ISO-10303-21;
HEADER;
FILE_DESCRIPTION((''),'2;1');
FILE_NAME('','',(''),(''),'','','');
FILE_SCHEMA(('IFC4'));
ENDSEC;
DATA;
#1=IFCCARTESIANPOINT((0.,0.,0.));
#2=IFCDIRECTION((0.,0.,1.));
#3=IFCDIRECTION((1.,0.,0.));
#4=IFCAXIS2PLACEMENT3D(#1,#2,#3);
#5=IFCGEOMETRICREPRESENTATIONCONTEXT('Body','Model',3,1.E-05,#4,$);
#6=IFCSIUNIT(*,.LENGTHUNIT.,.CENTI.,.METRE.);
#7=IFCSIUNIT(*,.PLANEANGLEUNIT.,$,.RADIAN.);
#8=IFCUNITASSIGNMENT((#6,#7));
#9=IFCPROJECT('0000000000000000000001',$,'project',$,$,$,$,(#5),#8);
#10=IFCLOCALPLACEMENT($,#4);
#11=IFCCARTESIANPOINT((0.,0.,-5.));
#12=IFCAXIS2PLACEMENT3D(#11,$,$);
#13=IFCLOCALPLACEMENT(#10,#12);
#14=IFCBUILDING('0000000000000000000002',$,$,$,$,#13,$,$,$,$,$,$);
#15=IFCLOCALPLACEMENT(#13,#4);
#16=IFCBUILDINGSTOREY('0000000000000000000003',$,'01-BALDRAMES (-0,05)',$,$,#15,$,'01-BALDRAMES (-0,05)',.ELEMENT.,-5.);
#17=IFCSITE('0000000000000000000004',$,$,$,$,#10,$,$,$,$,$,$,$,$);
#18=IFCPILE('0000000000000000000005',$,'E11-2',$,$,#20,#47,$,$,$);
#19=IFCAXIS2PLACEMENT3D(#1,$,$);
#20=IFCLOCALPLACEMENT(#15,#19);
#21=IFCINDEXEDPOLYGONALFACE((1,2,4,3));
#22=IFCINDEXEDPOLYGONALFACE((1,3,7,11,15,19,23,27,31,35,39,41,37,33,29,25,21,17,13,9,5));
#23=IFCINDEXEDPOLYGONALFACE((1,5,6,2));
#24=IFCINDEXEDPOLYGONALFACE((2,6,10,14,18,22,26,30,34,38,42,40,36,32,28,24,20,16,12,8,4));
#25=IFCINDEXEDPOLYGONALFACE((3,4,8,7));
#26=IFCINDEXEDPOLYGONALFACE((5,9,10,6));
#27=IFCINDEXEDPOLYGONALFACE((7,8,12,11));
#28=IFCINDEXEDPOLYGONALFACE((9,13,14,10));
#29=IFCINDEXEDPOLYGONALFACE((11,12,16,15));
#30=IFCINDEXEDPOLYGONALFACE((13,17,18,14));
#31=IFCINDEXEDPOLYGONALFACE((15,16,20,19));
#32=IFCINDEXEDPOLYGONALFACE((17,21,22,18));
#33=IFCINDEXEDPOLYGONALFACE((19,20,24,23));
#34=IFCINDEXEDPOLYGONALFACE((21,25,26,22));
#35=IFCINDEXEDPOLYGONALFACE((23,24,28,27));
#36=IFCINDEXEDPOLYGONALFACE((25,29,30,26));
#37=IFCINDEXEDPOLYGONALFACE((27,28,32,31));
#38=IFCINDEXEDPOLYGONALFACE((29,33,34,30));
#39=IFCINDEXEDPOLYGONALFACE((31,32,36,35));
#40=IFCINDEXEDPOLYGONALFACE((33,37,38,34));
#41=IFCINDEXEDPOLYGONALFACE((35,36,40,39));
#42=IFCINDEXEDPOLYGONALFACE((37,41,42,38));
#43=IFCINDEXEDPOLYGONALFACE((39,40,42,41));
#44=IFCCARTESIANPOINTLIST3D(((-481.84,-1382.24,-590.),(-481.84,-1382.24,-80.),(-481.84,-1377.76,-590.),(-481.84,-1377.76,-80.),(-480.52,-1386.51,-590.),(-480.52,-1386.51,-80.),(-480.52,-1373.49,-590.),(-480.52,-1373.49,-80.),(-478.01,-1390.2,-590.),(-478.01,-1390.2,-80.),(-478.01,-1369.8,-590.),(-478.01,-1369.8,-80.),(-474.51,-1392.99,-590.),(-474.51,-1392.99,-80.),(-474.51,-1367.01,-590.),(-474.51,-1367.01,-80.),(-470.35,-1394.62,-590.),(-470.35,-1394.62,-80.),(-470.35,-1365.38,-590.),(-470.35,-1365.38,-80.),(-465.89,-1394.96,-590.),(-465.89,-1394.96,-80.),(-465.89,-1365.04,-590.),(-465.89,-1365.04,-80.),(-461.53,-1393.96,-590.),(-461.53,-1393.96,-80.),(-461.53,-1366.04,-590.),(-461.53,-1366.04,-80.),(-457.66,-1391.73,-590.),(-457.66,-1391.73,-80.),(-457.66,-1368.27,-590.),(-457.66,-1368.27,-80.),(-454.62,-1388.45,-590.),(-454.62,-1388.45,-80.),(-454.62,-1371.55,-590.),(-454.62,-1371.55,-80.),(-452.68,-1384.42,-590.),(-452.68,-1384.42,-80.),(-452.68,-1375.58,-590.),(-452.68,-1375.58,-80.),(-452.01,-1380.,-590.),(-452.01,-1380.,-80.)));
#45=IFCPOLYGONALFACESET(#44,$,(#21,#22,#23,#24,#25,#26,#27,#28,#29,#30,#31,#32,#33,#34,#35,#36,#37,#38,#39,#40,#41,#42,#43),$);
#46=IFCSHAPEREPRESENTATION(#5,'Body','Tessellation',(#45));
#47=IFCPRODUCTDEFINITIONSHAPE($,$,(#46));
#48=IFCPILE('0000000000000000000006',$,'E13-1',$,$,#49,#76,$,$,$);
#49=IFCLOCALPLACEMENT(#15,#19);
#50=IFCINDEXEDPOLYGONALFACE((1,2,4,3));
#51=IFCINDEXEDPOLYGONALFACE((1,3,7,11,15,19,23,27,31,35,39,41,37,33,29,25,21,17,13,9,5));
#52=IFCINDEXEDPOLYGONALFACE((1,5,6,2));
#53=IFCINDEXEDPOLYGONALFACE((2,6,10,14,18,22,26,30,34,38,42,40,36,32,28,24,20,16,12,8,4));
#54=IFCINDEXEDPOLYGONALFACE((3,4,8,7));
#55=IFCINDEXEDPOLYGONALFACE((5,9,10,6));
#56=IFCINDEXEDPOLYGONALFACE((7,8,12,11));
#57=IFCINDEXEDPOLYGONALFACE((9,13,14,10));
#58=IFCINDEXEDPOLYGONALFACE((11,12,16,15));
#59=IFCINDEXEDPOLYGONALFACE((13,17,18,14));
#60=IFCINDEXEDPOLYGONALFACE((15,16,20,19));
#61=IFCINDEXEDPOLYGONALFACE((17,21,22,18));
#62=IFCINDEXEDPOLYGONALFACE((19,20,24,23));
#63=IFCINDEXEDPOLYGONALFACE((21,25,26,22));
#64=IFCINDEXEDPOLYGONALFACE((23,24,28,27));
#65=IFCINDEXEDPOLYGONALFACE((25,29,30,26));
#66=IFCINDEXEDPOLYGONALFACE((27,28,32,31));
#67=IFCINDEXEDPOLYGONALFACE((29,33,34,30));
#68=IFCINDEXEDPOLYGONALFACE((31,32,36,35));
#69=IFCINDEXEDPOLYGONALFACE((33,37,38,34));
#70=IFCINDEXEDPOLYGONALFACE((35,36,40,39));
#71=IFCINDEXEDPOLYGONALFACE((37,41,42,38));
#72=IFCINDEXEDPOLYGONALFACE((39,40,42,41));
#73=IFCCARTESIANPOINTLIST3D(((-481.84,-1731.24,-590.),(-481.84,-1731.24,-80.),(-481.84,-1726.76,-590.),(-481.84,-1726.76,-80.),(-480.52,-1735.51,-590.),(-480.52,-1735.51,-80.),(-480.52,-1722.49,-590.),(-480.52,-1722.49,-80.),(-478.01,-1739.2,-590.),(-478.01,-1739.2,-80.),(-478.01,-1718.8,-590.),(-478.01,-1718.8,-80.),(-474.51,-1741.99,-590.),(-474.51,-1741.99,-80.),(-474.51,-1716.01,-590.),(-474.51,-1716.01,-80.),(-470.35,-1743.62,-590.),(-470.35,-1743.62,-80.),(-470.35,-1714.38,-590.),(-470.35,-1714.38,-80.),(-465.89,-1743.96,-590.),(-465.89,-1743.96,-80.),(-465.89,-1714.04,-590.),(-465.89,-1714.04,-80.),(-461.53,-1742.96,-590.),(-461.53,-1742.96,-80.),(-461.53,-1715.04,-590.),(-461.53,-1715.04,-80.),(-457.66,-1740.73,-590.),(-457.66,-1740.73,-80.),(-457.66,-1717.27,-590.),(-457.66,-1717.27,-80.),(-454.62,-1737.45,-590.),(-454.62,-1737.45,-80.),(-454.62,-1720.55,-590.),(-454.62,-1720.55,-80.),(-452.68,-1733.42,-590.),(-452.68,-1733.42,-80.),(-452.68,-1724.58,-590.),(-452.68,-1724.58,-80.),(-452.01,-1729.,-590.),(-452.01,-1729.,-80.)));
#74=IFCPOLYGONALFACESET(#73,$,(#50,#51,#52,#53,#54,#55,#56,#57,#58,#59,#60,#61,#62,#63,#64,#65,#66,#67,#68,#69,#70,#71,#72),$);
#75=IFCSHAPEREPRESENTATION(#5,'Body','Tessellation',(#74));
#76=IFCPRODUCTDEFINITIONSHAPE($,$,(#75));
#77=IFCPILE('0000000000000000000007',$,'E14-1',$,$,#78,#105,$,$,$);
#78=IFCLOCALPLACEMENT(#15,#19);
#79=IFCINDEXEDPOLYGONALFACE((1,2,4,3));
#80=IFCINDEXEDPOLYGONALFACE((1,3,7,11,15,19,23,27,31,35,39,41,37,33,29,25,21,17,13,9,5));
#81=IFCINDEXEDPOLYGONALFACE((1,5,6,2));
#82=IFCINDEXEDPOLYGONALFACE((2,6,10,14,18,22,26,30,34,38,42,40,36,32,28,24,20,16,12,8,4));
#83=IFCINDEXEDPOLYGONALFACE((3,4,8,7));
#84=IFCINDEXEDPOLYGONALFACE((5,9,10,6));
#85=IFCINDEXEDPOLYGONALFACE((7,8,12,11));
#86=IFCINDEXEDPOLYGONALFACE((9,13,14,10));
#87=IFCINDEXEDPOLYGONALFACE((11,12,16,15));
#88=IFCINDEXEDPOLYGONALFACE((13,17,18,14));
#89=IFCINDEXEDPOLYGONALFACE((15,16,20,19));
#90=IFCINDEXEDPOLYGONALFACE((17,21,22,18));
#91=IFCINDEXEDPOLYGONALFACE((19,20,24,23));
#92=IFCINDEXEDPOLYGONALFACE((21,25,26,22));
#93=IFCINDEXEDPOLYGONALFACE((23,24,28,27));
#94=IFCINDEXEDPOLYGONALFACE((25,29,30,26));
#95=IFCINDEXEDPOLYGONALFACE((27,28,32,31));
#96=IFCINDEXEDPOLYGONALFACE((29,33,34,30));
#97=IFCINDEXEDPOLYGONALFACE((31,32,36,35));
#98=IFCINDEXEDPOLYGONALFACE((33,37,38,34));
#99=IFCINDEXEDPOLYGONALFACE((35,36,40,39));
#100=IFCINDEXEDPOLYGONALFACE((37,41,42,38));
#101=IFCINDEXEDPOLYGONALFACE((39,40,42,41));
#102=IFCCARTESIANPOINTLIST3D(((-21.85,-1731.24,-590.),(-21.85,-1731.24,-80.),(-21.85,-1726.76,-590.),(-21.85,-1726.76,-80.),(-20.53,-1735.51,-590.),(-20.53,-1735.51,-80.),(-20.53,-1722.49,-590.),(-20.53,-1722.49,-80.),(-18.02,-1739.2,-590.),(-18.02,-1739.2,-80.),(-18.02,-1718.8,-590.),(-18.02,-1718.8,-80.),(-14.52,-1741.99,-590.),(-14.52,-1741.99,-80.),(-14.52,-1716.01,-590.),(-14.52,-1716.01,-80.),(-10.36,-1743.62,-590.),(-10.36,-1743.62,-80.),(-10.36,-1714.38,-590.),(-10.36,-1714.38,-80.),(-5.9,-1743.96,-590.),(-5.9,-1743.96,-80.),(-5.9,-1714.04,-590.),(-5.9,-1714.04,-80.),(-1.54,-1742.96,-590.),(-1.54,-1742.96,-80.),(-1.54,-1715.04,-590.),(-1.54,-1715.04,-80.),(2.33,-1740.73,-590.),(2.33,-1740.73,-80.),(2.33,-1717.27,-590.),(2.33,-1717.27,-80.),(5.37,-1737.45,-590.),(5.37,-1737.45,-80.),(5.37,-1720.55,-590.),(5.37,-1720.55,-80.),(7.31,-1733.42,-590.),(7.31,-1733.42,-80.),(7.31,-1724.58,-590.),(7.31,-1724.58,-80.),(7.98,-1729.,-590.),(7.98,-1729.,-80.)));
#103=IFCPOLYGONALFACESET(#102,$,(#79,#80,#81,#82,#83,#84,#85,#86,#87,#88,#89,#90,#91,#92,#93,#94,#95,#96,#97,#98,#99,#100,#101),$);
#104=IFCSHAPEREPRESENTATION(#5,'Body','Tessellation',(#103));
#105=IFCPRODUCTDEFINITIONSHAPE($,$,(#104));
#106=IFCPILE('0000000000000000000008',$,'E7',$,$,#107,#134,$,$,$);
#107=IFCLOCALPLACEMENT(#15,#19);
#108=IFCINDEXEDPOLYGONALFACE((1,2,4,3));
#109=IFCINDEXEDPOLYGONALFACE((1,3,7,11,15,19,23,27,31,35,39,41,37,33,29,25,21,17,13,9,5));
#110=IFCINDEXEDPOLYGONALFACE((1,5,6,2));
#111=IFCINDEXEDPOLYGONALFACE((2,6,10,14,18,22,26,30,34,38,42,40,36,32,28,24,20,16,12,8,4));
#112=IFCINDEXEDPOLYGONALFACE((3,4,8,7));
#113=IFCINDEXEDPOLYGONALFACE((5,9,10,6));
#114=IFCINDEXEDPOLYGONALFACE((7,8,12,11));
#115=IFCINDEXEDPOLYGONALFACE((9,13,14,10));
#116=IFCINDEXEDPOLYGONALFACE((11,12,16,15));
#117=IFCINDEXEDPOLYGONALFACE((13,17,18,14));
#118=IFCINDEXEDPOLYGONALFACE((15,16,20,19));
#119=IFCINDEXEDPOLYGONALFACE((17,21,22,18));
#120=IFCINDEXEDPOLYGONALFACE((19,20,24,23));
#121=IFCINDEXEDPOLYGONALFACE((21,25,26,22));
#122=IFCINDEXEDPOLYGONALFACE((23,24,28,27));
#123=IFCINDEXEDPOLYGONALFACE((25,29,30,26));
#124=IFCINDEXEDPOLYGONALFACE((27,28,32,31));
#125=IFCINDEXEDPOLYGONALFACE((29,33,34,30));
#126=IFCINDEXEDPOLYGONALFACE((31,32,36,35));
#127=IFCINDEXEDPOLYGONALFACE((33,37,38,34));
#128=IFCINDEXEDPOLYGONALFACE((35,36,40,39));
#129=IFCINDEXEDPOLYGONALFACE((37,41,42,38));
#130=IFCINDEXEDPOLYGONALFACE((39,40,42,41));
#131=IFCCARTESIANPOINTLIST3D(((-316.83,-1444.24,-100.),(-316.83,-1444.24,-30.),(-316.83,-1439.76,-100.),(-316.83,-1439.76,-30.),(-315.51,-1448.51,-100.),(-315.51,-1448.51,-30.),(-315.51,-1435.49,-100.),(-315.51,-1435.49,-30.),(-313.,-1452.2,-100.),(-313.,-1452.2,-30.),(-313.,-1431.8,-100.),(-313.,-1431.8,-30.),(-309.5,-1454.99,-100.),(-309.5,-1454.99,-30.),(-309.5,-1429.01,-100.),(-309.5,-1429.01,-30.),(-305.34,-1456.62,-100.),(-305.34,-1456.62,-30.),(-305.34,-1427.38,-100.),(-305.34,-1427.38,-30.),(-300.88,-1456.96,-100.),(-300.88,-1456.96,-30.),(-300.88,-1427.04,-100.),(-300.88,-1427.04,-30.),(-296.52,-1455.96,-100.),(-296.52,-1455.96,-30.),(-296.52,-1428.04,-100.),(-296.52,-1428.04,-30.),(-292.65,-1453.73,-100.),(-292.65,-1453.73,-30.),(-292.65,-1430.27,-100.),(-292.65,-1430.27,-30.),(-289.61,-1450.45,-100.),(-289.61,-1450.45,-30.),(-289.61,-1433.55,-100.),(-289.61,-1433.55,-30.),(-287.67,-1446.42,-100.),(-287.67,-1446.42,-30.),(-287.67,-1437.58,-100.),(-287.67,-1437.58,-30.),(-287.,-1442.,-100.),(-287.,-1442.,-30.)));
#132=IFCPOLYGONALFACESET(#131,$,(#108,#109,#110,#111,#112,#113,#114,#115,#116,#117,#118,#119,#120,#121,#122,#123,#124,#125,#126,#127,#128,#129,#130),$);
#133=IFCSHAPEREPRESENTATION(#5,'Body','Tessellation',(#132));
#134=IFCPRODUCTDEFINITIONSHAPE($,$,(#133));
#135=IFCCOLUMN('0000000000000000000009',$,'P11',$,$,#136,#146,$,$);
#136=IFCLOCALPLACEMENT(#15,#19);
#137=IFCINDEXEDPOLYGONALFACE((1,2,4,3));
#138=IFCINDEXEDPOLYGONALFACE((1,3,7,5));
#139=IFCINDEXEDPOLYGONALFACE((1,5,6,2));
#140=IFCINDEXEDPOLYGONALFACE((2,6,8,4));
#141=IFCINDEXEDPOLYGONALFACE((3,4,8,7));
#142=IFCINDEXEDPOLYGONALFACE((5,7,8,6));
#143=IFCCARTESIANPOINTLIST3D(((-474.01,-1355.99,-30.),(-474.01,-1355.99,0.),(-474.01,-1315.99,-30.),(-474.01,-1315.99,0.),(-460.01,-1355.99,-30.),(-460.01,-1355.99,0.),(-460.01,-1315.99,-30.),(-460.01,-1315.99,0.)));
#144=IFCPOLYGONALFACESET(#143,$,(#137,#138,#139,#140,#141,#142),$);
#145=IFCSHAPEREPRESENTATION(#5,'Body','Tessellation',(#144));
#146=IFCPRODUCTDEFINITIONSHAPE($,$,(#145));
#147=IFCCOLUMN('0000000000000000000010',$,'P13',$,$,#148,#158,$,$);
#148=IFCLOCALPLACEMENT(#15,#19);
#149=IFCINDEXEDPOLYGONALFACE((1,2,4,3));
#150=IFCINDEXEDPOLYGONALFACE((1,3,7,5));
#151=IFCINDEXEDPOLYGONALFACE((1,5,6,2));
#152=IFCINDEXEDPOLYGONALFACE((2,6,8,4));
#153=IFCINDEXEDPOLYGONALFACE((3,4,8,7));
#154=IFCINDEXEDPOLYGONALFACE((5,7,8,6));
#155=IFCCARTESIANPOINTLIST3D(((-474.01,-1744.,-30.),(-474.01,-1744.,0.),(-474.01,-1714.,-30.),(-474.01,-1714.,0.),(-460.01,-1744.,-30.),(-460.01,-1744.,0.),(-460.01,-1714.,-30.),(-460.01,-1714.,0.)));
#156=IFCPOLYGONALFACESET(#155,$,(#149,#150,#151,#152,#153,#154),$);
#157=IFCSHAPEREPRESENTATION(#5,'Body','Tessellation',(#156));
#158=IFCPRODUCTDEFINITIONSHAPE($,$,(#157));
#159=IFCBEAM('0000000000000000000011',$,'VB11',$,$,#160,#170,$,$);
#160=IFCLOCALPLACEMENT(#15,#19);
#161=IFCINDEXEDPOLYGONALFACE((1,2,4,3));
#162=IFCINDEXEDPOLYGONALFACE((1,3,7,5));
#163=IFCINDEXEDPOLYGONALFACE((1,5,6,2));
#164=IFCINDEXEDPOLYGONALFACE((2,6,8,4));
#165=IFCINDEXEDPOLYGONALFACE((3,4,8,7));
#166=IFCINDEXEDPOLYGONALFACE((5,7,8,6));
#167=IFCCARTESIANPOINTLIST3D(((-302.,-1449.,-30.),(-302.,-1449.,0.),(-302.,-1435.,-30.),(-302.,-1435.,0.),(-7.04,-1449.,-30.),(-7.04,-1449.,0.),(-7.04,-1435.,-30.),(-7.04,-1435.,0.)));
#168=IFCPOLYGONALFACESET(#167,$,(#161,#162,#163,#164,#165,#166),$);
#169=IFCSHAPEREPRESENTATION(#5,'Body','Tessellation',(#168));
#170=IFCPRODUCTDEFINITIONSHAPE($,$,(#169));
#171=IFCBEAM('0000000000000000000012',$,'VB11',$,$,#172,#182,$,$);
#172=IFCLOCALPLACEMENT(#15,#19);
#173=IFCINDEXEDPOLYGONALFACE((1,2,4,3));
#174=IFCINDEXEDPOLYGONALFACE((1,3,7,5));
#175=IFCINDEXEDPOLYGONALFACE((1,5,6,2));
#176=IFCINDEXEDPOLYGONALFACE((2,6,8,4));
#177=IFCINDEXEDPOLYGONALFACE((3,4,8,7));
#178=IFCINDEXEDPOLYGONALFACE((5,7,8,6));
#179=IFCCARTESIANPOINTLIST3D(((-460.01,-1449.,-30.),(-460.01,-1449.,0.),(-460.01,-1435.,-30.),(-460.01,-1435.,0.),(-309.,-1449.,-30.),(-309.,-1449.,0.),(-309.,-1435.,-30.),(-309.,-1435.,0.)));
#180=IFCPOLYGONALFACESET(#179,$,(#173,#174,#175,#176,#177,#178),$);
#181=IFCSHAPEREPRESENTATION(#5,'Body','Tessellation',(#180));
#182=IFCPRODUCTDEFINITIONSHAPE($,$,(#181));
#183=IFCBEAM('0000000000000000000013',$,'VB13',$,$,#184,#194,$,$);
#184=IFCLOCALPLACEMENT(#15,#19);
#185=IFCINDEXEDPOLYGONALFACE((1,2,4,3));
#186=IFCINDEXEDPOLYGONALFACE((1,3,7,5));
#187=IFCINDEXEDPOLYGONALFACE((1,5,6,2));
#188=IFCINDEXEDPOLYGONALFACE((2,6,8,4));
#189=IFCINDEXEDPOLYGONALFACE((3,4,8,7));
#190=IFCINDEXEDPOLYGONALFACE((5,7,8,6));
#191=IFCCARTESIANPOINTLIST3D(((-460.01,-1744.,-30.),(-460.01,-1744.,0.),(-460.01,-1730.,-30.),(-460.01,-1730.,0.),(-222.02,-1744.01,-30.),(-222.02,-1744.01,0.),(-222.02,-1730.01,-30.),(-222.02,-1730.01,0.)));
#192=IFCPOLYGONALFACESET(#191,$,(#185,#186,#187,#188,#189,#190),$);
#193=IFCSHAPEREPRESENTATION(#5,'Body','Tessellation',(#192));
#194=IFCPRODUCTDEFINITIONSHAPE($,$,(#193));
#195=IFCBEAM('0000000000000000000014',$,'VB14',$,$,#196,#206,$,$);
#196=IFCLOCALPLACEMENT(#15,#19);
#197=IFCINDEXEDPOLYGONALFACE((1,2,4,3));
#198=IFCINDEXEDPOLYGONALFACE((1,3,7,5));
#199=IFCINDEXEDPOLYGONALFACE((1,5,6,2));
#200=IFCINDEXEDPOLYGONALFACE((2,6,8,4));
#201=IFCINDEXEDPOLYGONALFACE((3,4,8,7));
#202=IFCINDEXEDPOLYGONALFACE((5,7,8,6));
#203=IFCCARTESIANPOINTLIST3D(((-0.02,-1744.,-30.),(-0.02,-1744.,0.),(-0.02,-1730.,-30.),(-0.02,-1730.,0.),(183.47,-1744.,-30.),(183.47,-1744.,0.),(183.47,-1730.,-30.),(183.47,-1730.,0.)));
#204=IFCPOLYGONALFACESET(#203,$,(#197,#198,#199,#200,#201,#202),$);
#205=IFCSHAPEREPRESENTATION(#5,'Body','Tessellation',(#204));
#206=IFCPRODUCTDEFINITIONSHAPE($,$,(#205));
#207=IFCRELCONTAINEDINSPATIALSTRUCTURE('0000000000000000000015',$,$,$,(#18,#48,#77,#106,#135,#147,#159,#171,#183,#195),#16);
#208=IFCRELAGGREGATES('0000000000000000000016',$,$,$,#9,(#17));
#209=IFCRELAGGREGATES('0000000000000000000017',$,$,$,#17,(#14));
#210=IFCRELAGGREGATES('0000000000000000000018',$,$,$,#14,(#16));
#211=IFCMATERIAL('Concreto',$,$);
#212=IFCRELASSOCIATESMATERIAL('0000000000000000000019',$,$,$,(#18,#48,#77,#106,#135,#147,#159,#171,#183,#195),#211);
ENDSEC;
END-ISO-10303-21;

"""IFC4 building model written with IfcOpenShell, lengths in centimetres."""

from ifc_helpers import new_model, si_unit, frame, origin_with_axes, origin_2d_with_axis, place, context, project, spatial, rectangle, circle, extrude, material, element, save


model = new_model("IFC4")

# Units and contexts
model_context = context("Model", 3, precision=1e-05, world=origin_with_axes(), identifier="Body")
ifc_project = project(units=[si_unit("LENGTHUNIT", "METRE", prefix="CENTI"), si_unit("PLANEANGLEUNIT", "RADIAN")], contexts=[model_context])

# Site, building, storey
site_placement = place(None, origin_with_axes())
site = spatial("IfcSite", under=ifc_project, at=site_placement)
building_placement = place(site_placement, frame((0.0, 0.0, -5.0)))
building = spatial("IfcBuilding", under=site, at=building_placement)
storey_placement = place(building_placement, origin_with_axes())
storey = spatial("IfcBuildingStorey", under=building, at=storey_placement, Name="01-BALDRAMES (-0,05)", LongName="01-BALDRAMES (-0,05)", CompositionType="ELEMENT", Elevation=-5.0)

# Piles
ifc_material = material(Name="Concreto")
for number, where, z_axis, x_axis, name in (
    (1, (-467.01, -1380.0, -80.0), (0.0, 0.0, 1.0), (1.0, 0.0, 0.0), "E11-2"),
    (2, (-467.01, -1729.0, -80.0), (0.0, 0.0, 1.0), (1.0, 0.0, 0.0), "E13-1"),
    (3, (-7.02, -1729.0, -80.0), (0.0, 0.0, 1.0), (1.0, 0.0, 0.0), "E14-1"),
):
    element("IfcPile", number, at=place(storey_placement, frame(where, z_axis=z_axis, x_axis=x_axis)), inside=storey, material=ifc_material, Name=name, context=model_context, shape_type="SweptSolid", body=[
        extrude(circle(Radius=15.0, at=origin_2d_with_axis()), frame((0.0, 0.0, -510.0), z_axis=(0.0, 0.0, 1.0), x_axis=(1.0, 0.0, 0.0)), (0.0, 0.0, 1.0), 510.0),
    ])
pile_placement = place(storey_placement, frame((-302.0, -1442.0, -30.0), z_axis=(0.0, 0.0, 1.0), x_axis=(1.0, 0.0, 0.0)))
element("IfcPile", 4, at=pile_placement, inside=storey, material=ifc_material, Name="E7", context=model_context, shape_type="SolidModel", body=[
    extrude(circle(Radius=15.0, at=origin_2d_with_axis()), frame((0.0, 0.0, -70.0), z_axis=(0.0, 0.0, 1.0), x_axis=(1.0, 0.0, 0.0)), (0.0, 0.0, 1.0), 70.0),
])

# Columns
column_1_placement = place(storey_placement, frame((-467.01, -1335.99, 0.0), z_axis=(0.0, 0.0, 1.0), x_axis=(1.0, 0.0, 0.0)))
element("IfcColumn", 5, at=column_1_placement, inside=storey, material=ifc_material, Name="P11", context=model_context, shape_type="SolidModel", body=[
    extrude(rectangle(XDim=14.0, YDim=40.0, at=origin_2d_with_axis()), origin_with_axes(), (0.0, 0.0, -1.0), 30.0),
])
column_2_placement = place(storey_placement, frame((-467.01, -1729.0, 0.0), z_axis=(0.0, 0.0, 1.0), x_axis=(1.0, 0.0, 0.0)))
element("IfcColumn", 6, at=column_2_placement, inside=storey, material=ifc_material, Name="P13", context=model_context, shape_type="SolidModel", body=[
    extrude(rectangle(XDim=14.0, YDim=30.0, at=origin_2d_with_axis()), origin_with_axes(), (0.0, 0.0, -1.0), 30.0),
])

# Beams
beam_1_placement = place(storey_placement, frame((-154.52, -1442.0, 0.0), z_axis=(0.0, 0.0, 1.0), x_axis=(1.0, 0.0, 0.0)))
element("IfcBeam", 7, at=beam_1_placement, inside=storey, material=ifc_material, Name="VB11", context=model_context, shape_type="SolidModel", body=[
    extrude(rectangle(XDim=14.0, YDim=30.0, at=origin_2d_with_axis()), frame((-147.48, 0.0, -15.0), z_axis=(1.0, 0.0, 0.0), x_axis=(0.0, -1.0, 0.0)), (0.0, 0.0, 1.0), 294.96),
])
beam_2_placement = place(storey_placement, frame((-384.5, -1442.0, 0.0), z_axis=(0.0, 0.0, 1.0), x_axis=(1.0, 0.0, 0.0)))
element("IfcBeam", 8, at=beam_2_placement, inside=storey, material=ifc_material, Name="VB11", context=model_context, shape_type="SolidModel", body=[
    extrude(rectangle(XDim=14.0, YDim=30.0, at=origin_2d_with_axis()), frame((-75.5, 0.0, -15.0), z_axis=(1.0, 0.0, 0.0), x_axis=(0.0, -1.0, 0.0)), (0.0, 0.0, 1.0), 151.01),
])
beam_3_placement = place(storey_placement, frame((-341.01, -1737.01, 0.0), z_axis=(0.0, 0.0, 1.0), x_axis=(1.0, 0.0, 0.0)))
element("IfcBeam", 9, at=beam_3_placement, inside=storey, material=ifc_material, Name="VB13", context=model_context, shape_type="SolidModel", body=[
    extrude(rectangle(XDim=14.0, YDim=30.0, at=origin_2d_with_axis()), frame((-119.0, 0.01, -15.0), z_axis=(1.0, -0.000042, 0.0), x_axis=(-0.000042, -1.0, 0.0)), (0.0, 0.0, 1.0), 237.99),
])
beam_4_placement = place(storey_placement, frame((91.72, -1737.0, 0.0), z_axis=(0.0, 0.0, 1.0), x_axis=(1.0, 0.0, 0.0)))
element("IfcBeam", 10, at=beam_4_placement, inside=storey, material=ifc_material, Name="VB14", context=model_context, shape_type="SolidModel", body=[
    extrude(rectangle(XDim=14.0, YDim=30.0, at=origin_2d_with_axis()), frame((-91.75, 0.0, -15.0), z_axis=(1.0, 0.0, 0.0), x_axis=(0.0, -1.0, 0.0)), (0.0, 0.0, 1.0), 183.49),
])

save(model, "model.ifc")
